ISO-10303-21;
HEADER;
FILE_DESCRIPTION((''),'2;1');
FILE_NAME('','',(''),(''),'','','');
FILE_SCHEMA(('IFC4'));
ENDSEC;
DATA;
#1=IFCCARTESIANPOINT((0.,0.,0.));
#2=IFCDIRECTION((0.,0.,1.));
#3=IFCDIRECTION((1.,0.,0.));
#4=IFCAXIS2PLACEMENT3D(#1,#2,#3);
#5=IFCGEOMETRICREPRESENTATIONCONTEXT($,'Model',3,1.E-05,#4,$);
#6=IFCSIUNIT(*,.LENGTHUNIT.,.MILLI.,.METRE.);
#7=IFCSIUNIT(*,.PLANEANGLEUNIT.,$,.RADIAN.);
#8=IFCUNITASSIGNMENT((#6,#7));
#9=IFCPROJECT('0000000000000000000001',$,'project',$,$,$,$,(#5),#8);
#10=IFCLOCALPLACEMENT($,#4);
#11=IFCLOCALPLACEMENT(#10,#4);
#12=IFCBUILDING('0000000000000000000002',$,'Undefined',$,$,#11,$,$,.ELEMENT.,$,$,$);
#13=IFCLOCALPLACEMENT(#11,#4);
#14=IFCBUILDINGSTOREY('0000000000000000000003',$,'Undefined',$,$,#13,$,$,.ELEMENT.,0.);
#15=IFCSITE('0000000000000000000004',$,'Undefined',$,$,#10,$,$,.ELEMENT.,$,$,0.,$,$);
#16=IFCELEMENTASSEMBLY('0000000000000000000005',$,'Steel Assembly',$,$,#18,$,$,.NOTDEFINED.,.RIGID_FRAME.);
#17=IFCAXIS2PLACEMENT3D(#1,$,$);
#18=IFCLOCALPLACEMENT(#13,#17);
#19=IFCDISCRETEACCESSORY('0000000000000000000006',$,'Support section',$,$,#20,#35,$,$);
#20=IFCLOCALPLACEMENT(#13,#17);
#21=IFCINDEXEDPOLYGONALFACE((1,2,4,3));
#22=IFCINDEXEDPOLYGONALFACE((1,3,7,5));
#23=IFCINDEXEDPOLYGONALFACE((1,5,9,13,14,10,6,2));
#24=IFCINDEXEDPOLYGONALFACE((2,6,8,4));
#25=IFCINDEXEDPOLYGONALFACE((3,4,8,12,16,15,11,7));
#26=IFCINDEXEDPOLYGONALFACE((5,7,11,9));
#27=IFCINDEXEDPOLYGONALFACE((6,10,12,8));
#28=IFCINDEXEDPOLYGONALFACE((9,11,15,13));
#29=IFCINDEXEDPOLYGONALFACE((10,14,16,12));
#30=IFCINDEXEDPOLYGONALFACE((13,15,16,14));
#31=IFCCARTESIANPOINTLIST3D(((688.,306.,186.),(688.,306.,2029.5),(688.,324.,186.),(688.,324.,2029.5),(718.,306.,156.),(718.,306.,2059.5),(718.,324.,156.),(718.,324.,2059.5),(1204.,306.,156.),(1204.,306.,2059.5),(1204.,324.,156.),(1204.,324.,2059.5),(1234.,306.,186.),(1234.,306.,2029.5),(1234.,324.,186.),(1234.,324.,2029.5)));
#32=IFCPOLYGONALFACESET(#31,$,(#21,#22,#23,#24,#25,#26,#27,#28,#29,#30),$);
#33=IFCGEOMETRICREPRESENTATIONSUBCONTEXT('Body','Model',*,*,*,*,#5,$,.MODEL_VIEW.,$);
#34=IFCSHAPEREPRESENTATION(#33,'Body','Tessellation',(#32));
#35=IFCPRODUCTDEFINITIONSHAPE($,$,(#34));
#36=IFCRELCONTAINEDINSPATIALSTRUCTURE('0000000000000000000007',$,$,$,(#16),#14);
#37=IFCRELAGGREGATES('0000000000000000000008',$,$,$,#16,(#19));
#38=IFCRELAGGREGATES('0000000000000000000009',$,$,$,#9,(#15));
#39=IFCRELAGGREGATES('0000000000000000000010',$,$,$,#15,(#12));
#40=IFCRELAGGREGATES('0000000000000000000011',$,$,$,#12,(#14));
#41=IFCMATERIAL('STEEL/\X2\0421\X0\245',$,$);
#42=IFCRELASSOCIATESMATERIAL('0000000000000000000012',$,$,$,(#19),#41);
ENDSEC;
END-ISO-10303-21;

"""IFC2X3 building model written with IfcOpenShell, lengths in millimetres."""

from ifc_helpers import new_model, si_unit, frame, origin_with_axes, origin_2d_with_axis, place, context, subcontext, project, spatial, polyline, rectangle, outline, extrude, material, element, aggregate, save


model = new_model("IFC2X3")

# Units and contexts
model_context = context("Model", 3, precision=1e-05, world=origin_with_axes())
body_context = subcontext(model_context, "Body", "Model", "MODEL_VIEW")
ifc_project = project(units=[si_unit("LENGTHUNIT", "METRE", prefix="MILLI"), si_unit("PLANEANGLEUNIT", "RADIAN")], contexts=[model_context])

# Site, building, storey
site_placement = place(None, origin_with_axes())
site = spatial("IfcSite", under=ifc_project, at=site_placement, Name="Undefined", CompositionType="ELEMENT", RefElevation=0.0)
building_placement = place(site_placement, origin_with_axes())
building = spatial("IfcBuilding", under=site, at=building_placement, Name="Undefined", CompositionType="ELEMENT")
storey_placement = place(building_placement, origin_with_axes())
storey = spatial("IfcBuildingStorey", under=building, at=storey_placement, Name="Undefined", CompositionType="ELEMENT", Elevation=0.0)

# Shared definitions
ifc_material_1 = material(Name="STEEL/С245")

# Element assembly
assembly_1_placement = place(storey_placement, origin_with_axes())
assembly_1 = element("IfcElementAssembly", 1, at=assembly_1_placement, inside=storey, Name="Steel Assembly", AssemblyPlace="NOTDEFINED", PredefinedType="RIGID_FRAME")

# Discrete accessory, openings
discrete_accessory_1_placement = place(assembly_1_placement, frame((961.0, 315.0, 156.0), z_axis=(0.0, 0.0, 1.0), x_axis=(1.0, 0.0, 0.0)))
discrete_accessory_1 = element("IfcDiscreteAccessory", 2, at=discrete_accessory_1_placement, material=ifc_material_1, Name="Support section", context=body_context, shape_type="SweptSolid", body=[
    extrude(rectangle(XDim=18.0, YDim=546.0, at=origin_2d_with_axis()), frame((0.0, 0.0, 1903.5), z_axis=(0.0, 0.0, -1.0), x_axis=(0.0, -1.0, 0.0)), (0.0, 0.0, 1.0), 1903.5),
])
opening_1_placement = place(assembly_1_placement, frame((961.0, 315.0, 156.0), z_axis=(0.0, 0.0, 1.0), x_axis=(1.0, 0.0, 0.0)))
element("IfcOpeningElement", 3, at=opening_1_placement, cuts=discrete_accessory_1, ObjectType="Recess", context=body_context, shape_type="SweptSolid", body=[
    extrude(outline(polyline([(0.0, 0.0), (30.0, 0.0), (0.0, 30.0), (0.0, 0.0)])), frame((273.0, 11.5, 0.0), z_axis=(0.0, -1.0, 0.0), x_axis=(0.0, 0.0, 1.0)), (0.0, 0.0, 1.0), 23.0),
])
opening_2_placement = place(assembly_1_placement, frame((961.0, 315.0, 156.0), z_axis=(0.0, 0.0, 1.0), x_axis=(1.0, 0.0, 0.0)))
element("IfcOpeningElement", 4, at=opening_2_placement, cuts=discrete_accessory_1, ObjectType="Recess", context=body_context, shape_type="SweptSolid", body=[
    extrude(outline(polyline([(0.0, 0.0), (30.0, 0.0), (0.0, 30.0), (0.0, 0.0)])), frame((-273.0, -11.5, 0.0), z_axis=(0.0, 1.0, 0.0), x_axis=(0.0, 0.0, 1.0)), (0.0, 0.0, 1.0), 23.0),
])
opening_3_placement = place(assembly_1_placement, frame((961.0, 315.0, 156.0), z_axis=(0.0, 0.0, 1.0), x_axis=(1.0, 0.0, 0.0)))
element("IfcOpeningElement", 5, at=opening_3_placement, cuts=discrete_accessory_1, ObjectType="Recess", context=body_context, shape_type="SweptSolid", body=[
    extrude(outline(polyline([(0.0, 0.0), (30.0, 0.0), (0.0, 30.0), (0.0, 0.0)])), frame((-273.0, 11.9, 1903.5), z_axis=(0.0, -1.0, 0.0), x_axis=(0.0, 0.0, -1.0)), (0.0, 0.0, 1.0), 23.0),
])
opening_4_placement = place(assembly_1_placement, frame((961.0, 315.0, 156.0), z_axis=(0.0, 0.0, 1.0), x_axis=(1.0, 0.0, 0.0)))
element("IfcOpeningElement", 6, at=opening_4_placement, cuts=discrete_accessory_1, ObjectType="Recess", context=body_context, shape_type="SweptSolid", body=[
    extrude(outline(polyline([(0.0, 0.0), (30.0, 0.0), (0.0, 30.0), (0.0, 0.0)])), frame((273.0, -11.1, 1903.5), z_axis=(0.0, 1.0, 0.0), x_axis=(0.0, 0.0, -1.0)), (0.0, 0.0, 1.0), 23.0),
])
aggregate(assembly_1, [discrete_accessory_1])

save(model, "model.ifc")
